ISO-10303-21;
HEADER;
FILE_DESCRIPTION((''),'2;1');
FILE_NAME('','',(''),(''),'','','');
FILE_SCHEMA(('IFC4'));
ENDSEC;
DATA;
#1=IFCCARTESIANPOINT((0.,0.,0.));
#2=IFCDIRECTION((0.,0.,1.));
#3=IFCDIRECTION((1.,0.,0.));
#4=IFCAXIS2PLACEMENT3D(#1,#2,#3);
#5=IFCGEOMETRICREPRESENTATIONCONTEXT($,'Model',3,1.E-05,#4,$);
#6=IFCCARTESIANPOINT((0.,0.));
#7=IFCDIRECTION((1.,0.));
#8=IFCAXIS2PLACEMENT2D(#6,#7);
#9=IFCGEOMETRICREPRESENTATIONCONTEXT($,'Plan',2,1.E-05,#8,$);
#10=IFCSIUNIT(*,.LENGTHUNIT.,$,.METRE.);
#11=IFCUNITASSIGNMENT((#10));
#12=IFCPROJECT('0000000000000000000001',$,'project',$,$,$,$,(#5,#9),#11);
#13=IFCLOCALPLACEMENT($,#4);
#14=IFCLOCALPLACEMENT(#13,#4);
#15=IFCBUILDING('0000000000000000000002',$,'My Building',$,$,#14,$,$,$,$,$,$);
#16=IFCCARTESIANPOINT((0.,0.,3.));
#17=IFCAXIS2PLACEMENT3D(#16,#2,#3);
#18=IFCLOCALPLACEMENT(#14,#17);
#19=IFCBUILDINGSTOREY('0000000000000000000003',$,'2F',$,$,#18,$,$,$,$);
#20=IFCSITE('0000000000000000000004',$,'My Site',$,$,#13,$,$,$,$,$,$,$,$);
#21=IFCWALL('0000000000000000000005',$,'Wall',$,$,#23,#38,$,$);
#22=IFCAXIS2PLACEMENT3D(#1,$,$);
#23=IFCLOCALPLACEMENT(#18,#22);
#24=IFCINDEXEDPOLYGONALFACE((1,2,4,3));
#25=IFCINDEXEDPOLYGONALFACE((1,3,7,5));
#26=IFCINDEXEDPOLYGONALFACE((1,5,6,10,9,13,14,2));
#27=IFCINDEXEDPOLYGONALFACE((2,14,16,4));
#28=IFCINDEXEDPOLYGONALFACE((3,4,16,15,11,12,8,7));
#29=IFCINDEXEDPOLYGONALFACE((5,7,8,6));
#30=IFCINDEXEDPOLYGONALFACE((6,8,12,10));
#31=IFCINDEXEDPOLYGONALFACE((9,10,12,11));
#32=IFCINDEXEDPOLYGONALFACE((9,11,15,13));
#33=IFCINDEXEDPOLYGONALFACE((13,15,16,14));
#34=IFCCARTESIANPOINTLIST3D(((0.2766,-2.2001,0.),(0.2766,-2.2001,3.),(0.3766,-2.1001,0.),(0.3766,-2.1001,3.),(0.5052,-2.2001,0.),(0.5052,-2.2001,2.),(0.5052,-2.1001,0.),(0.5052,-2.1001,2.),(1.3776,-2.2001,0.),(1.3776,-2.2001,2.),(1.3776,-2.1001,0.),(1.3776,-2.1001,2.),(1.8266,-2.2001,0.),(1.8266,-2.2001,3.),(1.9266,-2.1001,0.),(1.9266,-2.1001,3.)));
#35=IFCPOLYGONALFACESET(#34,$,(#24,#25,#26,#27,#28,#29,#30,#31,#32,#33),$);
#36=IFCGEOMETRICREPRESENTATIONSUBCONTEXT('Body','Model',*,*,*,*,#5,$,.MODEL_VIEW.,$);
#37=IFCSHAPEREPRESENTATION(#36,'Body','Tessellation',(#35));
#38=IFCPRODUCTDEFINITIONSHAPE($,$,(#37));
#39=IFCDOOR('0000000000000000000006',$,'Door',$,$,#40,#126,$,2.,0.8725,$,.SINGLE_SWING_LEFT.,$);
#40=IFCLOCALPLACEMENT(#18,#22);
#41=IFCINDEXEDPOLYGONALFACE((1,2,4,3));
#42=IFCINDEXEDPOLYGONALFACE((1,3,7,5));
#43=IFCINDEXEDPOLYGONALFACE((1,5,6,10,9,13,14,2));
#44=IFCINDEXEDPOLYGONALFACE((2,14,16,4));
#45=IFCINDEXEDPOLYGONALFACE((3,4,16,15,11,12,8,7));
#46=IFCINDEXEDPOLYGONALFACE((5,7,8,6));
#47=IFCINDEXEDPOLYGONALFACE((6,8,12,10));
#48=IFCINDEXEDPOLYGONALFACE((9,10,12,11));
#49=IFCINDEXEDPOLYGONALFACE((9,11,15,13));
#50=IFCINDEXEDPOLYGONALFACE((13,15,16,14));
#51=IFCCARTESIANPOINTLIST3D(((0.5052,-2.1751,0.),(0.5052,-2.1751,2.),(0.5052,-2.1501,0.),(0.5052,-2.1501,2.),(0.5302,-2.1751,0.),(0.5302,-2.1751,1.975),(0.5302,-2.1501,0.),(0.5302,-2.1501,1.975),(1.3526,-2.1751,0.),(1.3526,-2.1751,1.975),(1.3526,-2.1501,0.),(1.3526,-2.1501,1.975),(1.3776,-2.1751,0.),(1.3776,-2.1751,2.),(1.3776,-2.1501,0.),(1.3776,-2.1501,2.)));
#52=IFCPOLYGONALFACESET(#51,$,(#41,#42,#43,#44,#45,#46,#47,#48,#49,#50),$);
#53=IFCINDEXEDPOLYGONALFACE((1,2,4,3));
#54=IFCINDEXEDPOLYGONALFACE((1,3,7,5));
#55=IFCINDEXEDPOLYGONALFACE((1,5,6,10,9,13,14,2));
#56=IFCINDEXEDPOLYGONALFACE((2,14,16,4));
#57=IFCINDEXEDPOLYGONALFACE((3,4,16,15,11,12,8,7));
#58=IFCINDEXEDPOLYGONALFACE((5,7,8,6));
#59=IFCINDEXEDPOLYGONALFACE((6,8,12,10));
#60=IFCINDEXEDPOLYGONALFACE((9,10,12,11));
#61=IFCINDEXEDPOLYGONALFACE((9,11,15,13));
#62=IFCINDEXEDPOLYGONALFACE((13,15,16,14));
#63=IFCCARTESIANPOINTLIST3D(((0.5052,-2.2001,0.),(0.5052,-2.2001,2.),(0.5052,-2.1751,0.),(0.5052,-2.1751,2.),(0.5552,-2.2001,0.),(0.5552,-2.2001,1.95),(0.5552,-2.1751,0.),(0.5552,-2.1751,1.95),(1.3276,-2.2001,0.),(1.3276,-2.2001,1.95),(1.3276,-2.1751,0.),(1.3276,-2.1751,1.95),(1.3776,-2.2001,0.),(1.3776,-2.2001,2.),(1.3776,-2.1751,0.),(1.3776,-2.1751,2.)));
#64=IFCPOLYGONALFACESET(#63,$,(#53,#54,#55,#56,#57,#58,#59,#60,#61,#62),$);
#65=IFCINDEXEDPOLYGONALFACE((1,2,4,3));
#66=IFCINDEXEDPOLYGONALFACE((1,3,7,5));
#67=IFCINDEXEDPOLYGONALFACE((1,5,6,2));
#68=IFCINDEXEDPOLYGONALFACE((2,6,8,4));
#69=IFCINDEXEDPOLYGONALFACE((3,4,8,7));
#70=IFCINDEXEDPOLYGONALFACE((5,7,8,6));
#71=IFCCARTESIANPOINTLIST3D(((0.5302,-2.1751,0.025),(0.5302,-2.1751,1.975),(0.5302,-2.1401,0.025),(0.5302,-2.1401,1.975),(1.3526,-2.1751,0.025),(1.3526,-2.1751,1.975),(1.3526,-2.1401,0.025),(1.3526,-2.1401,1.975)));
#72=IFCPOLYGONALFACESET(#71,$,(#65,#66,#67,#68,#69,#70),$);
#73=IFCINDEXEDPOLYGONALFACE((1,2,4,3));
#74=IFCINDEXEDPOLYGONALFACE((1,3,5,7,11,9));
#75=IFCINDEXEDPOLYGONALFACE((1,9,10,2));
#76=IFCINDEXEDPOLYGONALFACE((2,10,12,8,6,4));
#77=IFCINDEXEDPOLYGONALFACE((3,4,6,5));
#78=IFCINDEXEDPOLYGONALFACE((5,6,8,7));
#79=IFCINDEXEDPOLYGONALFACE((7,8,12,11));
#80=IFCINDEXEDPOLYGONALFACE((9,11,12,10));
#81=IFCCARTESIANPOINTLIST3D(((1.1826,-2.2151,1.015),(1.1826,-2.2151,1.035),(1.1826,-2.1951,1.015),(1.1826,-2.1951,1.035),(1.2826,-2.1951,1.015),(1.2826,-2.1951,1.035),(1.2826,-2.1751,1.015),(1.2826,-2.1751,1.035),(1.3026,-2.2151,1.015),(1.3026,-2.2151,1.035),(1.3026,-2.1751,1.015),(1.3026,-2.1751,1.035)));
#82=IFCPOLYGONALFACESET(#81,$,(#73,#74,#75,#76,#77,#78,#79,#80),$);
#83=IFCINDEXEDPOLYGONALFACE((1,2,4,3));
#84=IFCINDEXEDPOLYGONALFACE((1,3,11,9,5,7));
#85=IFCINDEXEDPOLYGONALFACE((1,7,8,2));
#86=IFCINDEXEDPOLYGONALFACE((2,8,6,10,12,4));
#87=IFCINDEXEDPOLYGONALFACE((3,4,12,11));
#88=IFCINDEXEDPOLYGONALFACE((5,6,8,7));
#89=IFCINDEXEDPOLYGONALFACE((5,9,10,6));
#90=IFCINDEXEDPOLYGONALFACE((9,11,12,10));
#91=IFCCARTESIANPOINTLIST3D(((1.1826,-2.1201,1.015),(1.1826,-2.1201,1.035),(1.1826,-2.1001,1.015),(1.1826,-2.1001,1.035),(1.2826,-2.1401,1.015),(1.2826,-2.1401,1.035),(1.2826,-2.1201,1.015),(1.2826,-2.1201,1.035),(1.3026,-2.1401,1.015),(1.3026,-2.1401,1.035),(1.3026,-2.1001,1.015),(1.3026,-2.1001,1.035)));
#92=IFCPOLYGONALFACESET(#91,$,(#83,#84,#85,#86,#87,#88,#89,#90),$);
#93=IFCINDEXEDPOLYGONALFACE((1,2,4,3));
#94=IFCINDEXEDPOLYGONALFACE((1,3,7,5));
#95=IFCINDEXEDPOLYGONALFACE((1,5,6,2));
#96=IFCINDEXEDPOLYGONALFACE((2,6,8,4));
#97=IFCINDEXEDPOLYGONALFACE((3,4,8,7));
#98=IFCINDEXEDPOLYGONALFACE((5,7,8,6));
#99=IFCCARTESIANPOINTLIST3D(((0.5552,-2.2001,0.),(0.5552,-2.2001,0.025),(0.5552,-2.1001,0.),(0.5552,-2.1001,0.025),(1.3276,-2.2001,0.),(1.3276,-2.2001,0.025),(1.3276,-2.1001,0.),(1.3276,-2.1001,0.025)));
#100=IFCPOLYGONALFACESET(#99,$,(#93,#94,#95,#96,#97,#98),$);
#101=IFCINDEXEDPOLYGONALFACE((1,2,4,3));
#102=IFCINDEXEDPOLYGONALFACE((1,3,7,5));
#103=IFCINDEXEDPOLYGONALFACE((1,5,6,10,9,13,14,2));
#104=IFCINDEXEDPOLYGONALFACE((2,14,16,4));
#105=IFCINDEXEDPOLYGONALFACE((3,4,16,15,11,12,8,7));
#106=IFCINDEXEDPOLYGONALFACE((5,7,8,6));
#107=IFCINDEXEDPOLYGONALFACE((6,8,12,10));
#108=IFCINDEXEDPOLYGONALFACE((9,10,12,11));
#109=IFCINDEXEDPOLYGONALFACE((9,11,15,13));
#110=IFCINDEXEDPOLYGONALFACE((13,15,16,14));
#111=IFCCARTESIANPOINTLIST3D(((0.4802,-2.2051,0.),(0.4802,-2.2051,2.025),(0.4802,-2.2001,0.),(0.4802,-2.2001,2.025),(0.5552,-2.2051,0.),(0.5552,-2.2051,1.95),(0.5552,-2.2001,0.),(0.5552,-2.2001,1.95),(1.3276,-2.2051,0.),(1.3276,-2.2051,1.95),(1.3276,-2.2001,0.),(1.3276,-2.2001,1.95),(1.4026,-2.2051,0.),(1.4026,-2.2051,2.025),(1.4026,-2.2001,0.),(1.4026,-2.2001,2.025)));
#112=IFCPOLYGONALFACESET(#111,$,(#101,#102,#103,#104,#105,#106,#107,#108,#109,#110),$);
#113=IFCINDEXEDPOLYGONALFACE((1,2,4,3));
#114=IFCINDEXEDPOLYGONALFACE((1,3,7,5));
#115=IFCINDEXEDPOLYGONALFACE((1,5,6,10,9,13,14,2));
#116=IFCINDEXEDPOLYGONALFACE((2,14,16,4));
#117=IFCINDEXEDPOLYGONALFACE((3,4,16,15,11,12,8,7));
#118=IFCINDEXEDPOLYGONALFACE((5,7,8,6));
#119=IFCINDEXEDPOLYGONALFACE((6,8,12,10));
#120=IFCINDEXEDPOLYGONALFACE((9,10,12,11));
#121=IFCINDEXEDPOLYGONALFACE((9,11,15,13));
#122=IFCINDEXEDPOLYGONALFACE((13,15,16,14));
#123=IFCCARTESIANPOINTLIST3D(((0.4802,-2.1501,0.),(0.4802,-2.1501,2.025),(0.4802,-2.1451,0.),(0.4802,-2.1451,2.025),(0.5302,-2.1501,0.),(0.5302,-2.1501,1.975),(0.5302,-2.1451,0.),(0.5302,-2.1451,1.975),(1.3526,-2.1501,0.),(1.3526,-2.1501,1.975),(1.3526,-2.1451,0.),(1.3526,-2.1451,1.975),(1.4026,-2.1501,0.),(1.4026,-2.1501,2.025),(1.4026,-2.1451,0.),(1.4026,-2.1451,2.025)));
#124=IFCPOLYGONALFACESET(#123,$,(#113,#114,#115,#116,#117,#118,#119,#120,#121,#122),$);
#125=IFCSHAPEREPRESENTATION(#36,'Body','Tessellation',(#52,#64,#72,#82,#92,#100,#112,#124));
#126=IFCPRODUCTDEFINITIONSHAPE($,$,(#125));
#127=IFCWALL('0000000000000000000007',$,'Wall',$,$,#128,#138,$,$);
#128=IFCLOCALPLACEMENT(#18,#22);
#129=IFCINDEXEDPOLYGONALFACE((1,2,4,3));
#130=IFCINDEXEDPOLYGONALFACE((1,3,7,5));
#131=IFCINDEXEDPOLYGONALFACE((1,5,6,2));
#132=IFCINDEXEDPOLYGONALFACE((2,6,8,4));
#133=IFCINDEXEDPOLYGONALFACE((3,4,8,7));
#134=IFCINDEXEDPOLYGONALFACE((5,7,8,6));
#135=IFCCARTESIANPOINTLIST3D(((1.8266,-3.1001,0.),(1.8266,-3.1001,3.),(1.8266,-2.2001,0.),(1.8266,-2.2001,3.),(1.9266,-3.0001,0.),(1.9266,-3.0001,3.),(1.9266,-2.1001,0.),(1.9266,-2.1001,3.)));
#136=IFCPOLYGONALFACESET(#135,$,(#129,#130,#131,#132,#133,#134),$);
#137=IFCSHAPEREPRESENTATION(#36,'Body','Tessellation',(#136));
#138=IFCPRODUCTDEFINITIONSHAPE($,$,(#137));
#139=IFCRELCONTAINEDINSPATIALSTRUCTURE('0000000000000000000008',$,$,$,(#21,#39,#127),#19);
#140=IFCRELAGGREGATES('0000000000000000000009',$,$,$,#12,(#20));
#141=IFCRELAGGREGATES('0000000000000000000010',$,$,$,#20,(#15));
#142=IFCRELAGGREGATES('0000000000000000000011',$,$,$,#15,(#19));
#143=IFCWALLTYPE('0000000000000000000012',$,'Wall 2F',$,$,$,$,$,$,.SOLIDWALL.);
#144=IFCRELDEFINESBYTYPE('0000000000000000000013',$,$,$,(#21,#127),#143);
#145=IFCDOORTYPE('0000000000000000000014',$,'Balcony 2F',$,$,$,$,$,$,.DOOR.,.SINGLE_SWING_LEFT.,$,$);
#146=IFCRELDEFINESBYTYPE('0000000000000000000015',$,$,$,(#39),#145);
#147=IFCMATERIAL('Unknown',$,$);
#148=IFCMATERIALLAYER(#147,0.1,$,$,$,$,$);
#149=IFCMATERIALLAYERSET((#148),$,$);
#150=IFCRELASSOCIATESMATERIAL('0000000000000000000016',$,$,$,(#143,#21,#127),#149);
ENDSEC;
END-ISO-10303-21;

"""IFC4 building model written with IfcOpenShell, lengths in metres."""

from ifc_helpers import new_model, entity, si_unit, frame, origin_with_axes, origin_2d_with_axis, place, context, subcontext, project, spatial, line, indexed_curve, outline, extrude, shape, source, transform, mapped, material, layer, layer_set, layer_usage, type_object, type_shapes, element, fill, save


model = new_model("IFC4")

# Units and contexts
model_context = context("Model", 3, precision=1e-05, world=origin_with_axes())
plan_context = context("Plan", 2, precision=1e-05, world=origin_2d_with_axis())
body_context_1 = subcontext(model_context, "Body", "Model", "MODEL_VIEW")
body_context_2 = subcontext(plan_context, "Body", "Plan", "PLAN_VIEW")
ifc_project = project(units=[si_unit("LENGTHUNIT", "METRE")], contexts=[model_context, plan_context])

# Site, building, storey
site_placement = place(None, origin_with_axes())
site = spatial("IfcSite", under=ifc_project, at=site_placement, Name="My Site")
building_placement = place(site_placement, origin_with_axes())
building = spatial("IfcBuilding", under=site, at=building_placement, Name="My Building")
storey_placement = place(building_placement, frame((0.0, 0.0, 3.0), z_axis=(0.0, 0.0, 1.0), x_axis=(1.0, 0.0, 0.0)))
storey = spatial("IfcBuildingStorey", under=building, at=storey_placement, Name="2F")

# Shared definitions
ifc_material = material(Name="Unknown")

# Shared definitions
ifc_layer_1 = layer(ifc_material, 0.1)
ifc_layer_set_1 = layer_set([ifc_layer_1])
wall_type = type_object("IfcWallType", Name="Wall 2F", PredefinedType="SOLIDWALL", material=ifc_layer_set_1)

# Wall, opening, door
ifc_layer_usage_1 = layer_usage(ifc_layer_set_1, "AXIS2", "POSITIVE", 0.0)
wall_1_placement = place(storey_placement, frame((0.2766, -2.2001, 0.0), z_axis=(0.0, 0.0, 1.0), x_axis=(1.0, 0.0, 0.0)))
wall_1 = element("IfcWall", 1, at=wall_1_placement, inside=storey, type_object=wall_type, material=ifc_layer_usage_1, Name="Wall", context=body_context_1, shape_type="SweptSolid", body=[
    extrude(outline(indexed_curve([(0.0, 0.0), (0.1, 0.1), (1.65, 0.1), (1.55, 0.0)], segments=[line(1, 2, 3, 4, 1)])), origin_with_axes(), (0.0, 0.0, 1.0), 3.0),
])
shared_shape_1 = source(origin_with_axes(), body_context_1, "Body", "SweptSolid", [
    extrude(outline(indexed_curve([(0.0, 0.0), (0.8725, 0.0), (0.8725, 2.0), (0.0, 2.0)], segments=[line(1, 2, 3, 4, 1)])), frame((0.0, -0.6, 0.0), z_axis=(0.0, -1.0, 0.0), x_axis=(1.0, 0.0, 0.0)), (0.0, 0.0, -1.0), 1.2),
])
opening_1_placement = place(wall_1_placement, frame((0.2286, 0.0, 0.0), z_axis=(0.0, 0.0, 1.0), x_axis=(1.0, 0.0, 0.0)))
opening_1 = element("IfcOpeningElement", 2, at=opening_1_placement, cuts=wall_1, PredefinedType="OPENING", context=body_context_1, shape_type="MappedRepresentation", body=[
    mapped(shared_shape_1, transform((0.0, 0.0, 0.0), x_axis=(1.0, 0.0, 0.0), y_axis=(0.0, 1.0, 0.0), z_axis=(0.0, 0.0, 1.0), scale=1.0)),
])
door_type_1 = type_object("IfcDoorType", Name="Balcony 2F", OperationType="SINGLE_SWING_LEFT", PredefinedType="DOOR")
shared_shape_2 = source(origin_with_axes(), body_context_1, "Body", "SweptSolid", [
    extrude(outline(indexed_curve([(0.0, 0.0), (0.0, 2.0), (0.8725, 2.0), (0.8725, 0.0), (0.8475, 0.0), (0.8475, 1.975), (0.025, 1.975), (0.025, 0.0)], segments=[line(1, 2, 3, 4, 5, 6, 7, 8, 1)])), frame((0.0, 0.025, 0.0), z_axis=(0.0, -1.0, 0.0), x_axis=(1.0, 0.0, 0.0)), (0.0, 0.0, -1.0), 0.025),
    extrude(outline(indexed_curve([(0.0, 0.0), (0.0, 2.0), (0.8725, 2.0), (0.8725, 0.0), (0.8225, 0.0), (0.8225, 1.95), (0.05, 1.95), (0.05, 0.0)], segments=[line(1, 2, 3, 4, 5, 6, 7, 8, 1)])), frame((0.0, 0.0, 0.0), z_axis=(0.0, -1.0, 0.0), x_axis=(1.0, 0.0, 0.0)), (0.0, 0.0, -1.0), 0.025),
    extrude(outline(indexed_curve([(0.0, 0.0), (0.8225, 0.0), (0.8225, 0.035), (0.0, 0.035)], segments=[line(1, 2, 3, 4, 1)])), frame((0.025, 0.025, 0.025), z_axis=(0.0, 0.0, 1.0), x_axis=(1.0, 0.0, 0.0)), (0.0, 0.0, 1.0), 1.95),
    extrude(outline(indexed_curve([(0.0, 0.0), (0.0, -0.04), (-0.12, -0.04), (-0.12, -0.02), (-0.02, -0.02), (-0.02, 0.0)], segments=[line(1, 2, 3, 4, 5, 6, 1)])), frame((0.7975, 0.025, 1.015), z_axis=(0.0, 0.0, 1.0), x_axis=(1.0, 0.0, 0.0)), (0.0, 0.0, 1.0), 0.02),
    extrude(outline(indexed_curve([(0.0, 0.0), (0.0, 0.04), (-0.12, 0.04), (-0.12, 0.02), (-0.02, 0.02), (-0.02, 0.0)], segments=[line(1, 2, 3, 4, 5, 6, 1)])), frame((0.7975, 0.06, 1.015), z_axis=(0.0, 0.0, 1.0), x_axis=(1.0, 0.0, 0.0)), (0.0, 0.0, 1.0), 0.02),
    extrude(outline(indexed_curve([(0.0, 0.0), (0.7725, 0.0), (0.7725, 0.1), (0.0, 0.1)], segments=[line(1, 2, 3, 4, 1)])), frame((0.05, 0.0, 0.0), z_axis=(0.0, 0.0, 1.0), x_axis=(1.0, 0.0, 0.0)), (0.0, 0.0, 1.0), 0.025),
    extrude(outline(indexed_curve([(0.0, 0.0), (0.0, 2.025), (0.9225, 2.025), (0.9225, 0.0), (0.8475, 0.0), (0.8475, 1.95), (0.075, 1.95), (0.075, 0.0)], segments=[line(1, 2, 3, 4, 5, 6, 7, 8, 1)])), frame((-0.025, -0.005, 0.0), z_axis=(0.0, -1.0, 0.0), x_axis=(1.0, 0.0, 0.0)), (0.0, 0.0, -1.0), 0.005),
    extrude(outline(indexed_curve([(0.0, 0.0), (0.0, 2.025), (0.9225, 2.025), (0.9225, 0.0), (0.8725, 0.0), (0.8725, 1.975), (0.05, 1.975), (0.05, 0.0)], segments=[line(1, 2, 3, 4, 5, 6, 7, 8, 1)])), frame((-0.025, 0.05, 0.0), z_axis=(0.0, -1.0, 0.0), x_axis=(1.0, 0.0, 0.0)), (0.0, 0.0, -1.0), 0.005),
])
shared_shape_3 = source(origin_with_axes(), body_context_2, "Body", "Curve2D", [
    entity("IfcIndexedPolyCurve", entity("IfcCartesianPointList2D", [[0.0, 0.0], [0.0, 0.05], [0.025, 0.05], [0.025, 0.025], [0.05, 0.025], [0.05, 0.0]]), [entity("IfcLineIndex", [1, 2, 3, 4, 5, 6, 1])]),
    entity("IfcIndexedPolyCurve", entity("IfcCartesianPointList2D", [[0.8725, 0.0], [0.8725, 0.05], [0.8475, 0.05], [0.8475, 0.025], [0.8225, 0.025], [0.8225, 0.0]]), [entity("IfcLineIndex", [1, 2, 3, 4, 5, 6, 1])]),
    entity("IfcTrimmedCurve", entity("IfcEllipse", entity("IfcAxis2Placement2D", entity("IfcCartesianPoint", [0.06, 0.05]), entity("IfcDirection", [1.0, 0.0])), 0.7875, 0.8225), [entity("IfcCartesianPoint", [0.8475, 0.05])], [entity("IfcCartesianPoint", [0.06, 0.8725])], True, "CARTESIAN"),
    entity("IfcIndexedPolyCurve", entity("IfcCartesianPointList2D", [[0.025, 0.05], [0.06, 0.05], [0.06, 0.8725], [0.025, 0.8725]]), [entity("IfcLineIndex", [1, 2, 3, 4, 1])]),
])
type_shapes(door_type_1, [shared_shape_2, shared_shape_3])
door_1_placement = place(opening_1_placement, frame((0.0, 0.0, 0.0), z_axis=(0.0, 0.0, 1.0), x_axis=(1.0, 0.0, 0.0)))
door_1 = element("IfcDoor", 3, at=door_1_placement, inside=storey, type_object=door_type_1, Name="Door", OperationType="SINGLE_SWING_LEFT", OverallHeight=2.0, OverallWidth=0.8725, shapes=[
    shape(body_context_1, "Body", "MappedRepresentation", [mapped(shared_shape_2, transform((0.0, 0.0, 0.0), x_axis=(1.0, 0.0, 0.0), y_axis=(0.0, 1.0, 0.0), z_axis=(0.0, 0.0, 1.0), scale=1.0))]),
    shape(body_context_2, "Body", "MappedRepresentation", [mapped(shared_shape_3, transform((0.0, 0.0, 0.0), x_axis=(1.0, 0.0, 0.0), y_axis=(0.0, 1.0, 0.0), z_axis=(0.0, 0.0, 1.0), scale=1.0))]),
])
fill(opening_1, door_1)

# Wall
ifc_layer_usage_2 = layer_usage(ifc_layer_set_1, "AXIS2", "POSITIVE", 0.0)
wall_2_placement = place(storey_placement, frame((1.8266, -2.2001, 0.0), z_axis=(0.0, 0.0, 1.0), x_axis=(0.0, -1.0, 0.0)))
element("IfcWall", 4, at=wall_2_placement, inside=storey, type_object=wall_type, material=ifc_layer_usage_2, Name="Wall", context=body_context_1, shape_type="SweptSolid", body=[
    extrude(outline(indexed_curve([(0.0, 0.0), (-0.1, 0.1), (0.8, 0.1), (0.9, 0.0)], segments=[line(1, 2, 3, 4, 1)])), origin_with_axes(), (0.0, 0.0, 1.0), 3.0),
])

save(model, "model.ifc")
